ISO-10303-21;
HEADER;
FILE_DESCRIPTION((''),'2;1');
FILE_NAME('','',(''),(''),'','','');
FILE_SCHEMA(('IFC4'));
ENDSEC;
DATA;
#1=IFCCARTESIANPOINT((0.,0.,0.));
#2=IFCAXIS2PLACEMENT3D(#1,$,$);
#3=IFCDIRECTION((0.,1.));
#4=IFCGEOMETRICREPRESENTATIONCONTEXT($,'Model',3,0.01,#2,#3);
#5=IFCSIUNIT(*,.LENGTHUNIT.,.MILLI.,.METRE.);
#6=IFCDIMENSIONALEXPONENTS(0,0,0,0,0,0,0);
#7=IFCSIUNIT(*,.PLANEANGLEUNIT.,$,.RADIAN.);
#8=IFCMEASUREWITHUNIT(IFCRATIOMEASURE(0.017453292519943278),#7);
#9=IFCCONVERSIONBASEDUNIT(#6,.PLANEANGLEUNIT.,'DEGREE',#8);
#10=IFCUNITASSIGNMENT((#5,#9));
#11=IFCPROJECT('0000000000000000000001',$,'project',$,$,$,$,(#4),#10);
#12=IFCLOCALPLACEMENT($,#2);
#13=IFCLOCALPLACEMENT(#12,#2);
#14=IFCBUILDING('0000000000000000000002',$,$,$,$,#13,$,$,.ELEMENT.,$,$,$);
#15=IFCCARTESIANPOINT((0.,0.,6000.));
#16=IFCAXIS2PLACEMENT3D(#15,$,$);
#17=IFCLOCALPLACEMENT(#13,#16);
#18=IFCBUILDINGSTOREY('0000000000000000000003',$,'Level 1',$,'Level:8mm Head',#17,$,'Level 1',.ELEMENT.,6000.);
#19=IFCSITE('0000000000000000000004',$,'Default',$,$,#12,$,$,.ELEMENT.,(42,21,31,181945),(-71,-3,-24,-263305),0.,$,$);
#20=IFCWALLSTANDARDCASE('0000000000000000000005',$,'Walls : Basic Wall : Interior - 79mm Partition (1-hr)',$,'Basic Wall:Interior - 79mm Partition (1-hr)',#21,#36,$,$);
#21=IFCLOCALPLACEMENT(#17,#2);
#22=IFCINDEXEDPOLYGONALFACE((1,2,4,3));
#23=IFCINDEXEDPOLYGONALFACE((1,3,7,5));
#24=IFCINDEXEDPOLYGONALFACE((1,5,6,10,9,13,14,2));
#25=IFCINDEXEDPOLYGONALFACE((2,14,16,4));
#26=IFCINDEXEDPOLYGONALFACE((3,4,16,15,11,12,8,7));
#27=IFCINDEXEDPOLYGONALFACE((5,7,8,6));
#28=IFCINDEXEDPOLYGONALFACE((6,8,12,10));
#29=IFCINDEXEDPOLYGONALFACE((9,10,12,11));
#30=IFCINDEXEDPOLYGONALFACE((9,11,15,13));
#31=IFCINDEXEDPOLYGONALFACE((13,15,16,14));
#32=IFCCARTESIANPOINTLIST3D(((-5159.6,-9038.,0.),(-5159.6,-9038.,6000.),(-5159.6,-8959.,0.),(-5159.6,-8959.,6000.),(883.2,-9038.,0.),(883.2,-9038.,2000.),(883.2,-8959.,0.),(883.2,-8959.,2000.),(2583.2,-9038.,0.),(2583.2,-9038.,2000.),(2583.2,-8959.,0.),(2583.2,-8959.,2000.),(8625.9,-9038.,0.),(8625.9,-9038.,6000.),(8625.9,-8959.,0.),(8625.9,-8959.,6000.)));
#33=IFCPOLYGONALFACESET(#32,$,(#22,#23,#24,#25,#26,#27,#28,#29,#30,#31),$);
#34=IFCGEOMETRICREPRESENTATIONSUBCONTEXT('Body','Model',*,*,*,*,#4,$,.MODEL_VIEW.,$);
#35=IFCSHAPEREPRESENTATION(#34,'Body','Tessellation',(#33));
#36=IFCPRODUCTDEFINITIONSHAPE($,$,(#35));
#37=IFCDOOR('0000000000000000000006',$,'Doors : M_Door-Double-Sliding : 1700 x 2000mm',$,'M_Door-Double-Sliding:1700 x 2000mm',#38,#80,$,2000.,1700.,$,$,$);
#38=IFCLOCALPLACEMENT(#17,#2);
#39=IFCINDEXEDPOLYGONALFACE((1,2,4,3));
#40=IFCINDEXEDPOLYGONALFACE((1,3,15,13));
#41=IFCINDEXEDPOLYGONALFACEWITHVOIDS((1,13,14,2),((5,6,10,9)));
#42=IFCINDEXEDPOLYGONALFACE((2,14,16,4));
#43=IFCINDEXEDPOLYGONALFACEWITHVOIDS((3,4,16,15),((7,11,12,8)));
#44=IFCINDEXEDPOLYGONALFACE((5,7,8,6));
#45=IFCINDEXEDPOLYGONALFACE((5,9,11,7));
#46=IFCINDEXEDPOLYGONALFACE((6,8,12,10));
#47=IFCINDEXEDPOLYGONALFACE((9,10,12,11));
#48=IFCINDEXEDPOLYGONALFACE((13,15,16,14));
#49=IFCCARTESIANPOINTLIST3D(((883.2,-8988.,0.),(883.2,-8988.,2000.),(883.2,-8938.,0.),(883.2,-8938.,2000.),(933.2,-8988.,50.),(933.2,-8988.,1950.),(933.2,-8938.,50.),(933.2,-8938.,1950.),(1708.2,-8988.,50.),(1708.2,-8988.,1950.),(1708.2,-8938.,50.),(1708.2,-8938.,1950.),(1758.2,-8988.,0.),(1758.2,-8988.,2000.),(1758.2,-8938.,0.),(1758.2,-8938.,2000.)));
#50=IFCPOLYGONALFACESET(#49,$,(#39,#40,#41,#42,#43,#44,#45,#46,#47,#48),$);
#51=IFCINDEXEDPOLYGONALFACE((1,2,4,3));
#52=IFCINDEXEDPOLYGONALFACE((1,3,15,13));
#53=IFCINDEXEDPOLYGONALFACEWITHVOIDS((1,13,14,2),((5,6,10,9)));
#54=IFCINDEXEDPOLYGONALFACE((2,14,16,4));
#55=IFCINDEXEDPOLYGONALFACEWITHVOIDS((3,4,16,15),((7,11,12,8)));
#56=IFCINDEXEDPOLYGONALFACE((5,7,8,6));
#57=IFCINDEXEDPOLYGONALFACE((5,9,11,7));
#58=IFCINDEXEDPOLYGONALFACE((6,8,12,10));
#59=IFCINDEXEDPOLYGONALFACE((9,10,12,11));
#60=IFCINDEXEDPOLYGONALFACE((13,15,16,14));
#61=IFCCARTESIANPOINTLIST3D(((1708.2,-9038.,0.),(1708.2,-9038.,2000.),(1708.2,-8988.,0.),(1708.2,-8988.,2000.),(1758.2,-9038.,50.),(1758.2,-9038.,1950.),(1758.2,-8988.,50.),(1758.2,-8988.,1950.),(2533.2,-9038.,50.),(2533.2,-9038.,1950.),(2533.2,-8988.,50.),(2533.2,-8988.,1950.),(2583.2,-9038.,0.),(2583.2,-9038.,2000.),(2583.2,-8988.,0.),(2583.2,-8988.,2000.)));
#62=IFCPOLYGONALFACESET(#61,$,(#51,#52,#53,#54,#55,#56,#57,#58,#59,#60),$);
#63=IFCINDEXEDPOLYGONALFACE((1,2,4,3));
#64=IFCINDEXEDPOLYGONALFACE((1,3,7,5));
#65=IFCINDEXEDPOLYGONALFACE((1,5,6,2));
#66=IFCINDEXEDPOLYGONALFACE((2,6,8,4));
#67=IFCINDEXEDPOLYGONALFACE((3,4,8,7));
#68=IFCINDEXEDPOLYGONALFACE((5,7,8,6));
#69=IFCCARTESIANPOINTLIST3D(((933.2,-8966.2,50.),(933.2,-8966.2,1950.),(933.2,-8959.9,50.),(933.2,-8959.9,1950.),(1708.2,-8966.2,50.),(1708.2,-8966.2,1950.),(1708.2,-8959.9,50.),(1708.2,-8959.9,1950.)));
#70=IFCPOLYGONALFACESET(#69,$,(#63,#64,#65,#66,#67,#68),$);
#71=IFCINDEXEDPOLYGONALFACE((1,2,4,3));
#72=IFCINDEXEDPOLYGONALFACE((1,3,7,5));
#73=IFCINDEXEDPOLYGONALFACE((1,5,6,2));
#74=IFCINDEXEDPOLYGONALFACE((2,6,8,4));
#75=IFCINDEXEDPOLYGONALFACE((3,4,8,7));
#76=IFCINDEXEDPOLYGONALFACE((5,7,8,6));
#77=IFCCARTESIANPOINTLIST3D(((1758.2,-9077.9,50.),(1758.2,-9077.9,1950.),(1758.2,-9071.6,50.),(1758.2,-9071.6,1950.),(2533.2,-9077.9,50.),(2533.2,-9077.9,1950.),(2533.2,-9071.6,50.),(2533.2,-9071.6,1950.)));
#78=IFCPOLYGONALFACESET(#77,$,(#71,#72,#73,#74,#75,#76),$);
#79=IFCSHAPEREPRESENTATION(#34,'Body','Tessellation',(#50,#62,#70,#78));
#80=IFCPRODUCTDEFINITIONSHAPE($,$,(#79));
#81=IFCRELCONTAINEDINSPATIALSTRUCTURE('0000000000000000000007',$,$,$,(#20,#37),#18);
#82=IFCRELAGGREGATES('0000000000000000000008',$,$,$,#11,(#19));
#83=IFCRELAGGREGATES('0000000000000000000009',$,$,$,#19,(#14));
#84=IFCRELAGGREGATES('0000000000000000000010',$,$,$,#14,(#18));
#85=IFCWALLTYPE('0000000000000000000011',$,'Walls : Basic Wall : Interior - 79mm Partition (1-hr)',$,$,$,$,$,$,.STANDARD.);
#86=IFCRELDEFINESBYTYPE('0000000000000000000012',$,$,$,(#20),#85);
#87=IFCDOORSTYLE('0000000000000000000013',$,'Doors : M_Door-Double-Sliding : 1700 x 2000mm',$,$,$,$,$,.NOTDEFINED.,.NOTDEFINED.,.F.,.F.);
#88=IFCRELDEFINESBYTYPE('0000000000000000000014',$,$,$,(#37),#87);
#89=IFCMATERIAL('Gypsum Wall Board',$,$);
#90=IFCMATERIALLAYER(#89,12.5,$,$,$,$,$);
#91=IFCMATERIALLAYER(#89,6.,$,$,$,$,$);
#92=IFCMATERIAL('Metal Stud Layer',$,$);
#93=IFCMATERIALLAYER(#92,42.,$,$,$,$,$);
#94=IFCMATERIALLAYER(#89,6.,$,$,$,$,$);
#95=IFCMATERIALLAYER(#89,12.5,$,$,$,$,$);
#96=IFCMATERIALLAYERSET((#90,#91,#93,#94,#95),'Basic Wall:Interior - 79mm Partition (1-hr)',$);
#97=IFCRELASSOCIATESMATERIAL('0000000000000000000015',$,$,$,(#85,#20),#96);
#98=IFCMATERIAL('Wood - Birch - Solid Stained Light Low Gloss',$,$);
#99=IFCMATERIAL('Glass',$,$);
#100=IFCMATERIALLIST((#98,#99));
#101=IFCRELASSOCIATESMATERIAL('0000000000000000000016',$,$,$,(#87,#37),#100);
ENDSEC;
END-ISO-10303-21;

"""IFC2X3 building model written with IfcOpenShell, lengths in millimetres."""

from ifc_helpers import new_model, entity, si_unit, converted_unit, direction, frame, frame_2d, origin, origin_2d_with_axis, place, context, subcontext, project, spatial, polyline, rectangle, outline, extrude, source, transform, mapped, material, material_list, layer, layer_set, layer_usage, type_object, type_shapes, element, fill, save


model = new_model("IFC2X3")

# Units and contexts
model_context = context("Model", 3, precision=0.01, world=origin(), true_north=direction((0.0, 1.0)))
body_context = subcontext(model_context, "Body", "Model", "MODEL_VIEW")
ifc_project = project(units=[si_unit("LENGTHUNIT", "METRE", prefix="MILLI"), converted_unit("PLANEANGLEUNIT", "DEGREE", entity("IfcRatioMeasure", 0.017453292519943278), si_unit("PLANEANGLEUNIT", "RADIAN"), dimensions=[0, 0, 0, 0, 0, 0, 0])], contexts=[model_context])

# Site, building, storey
site_placement = place(None, origin())
site = spatial("IfcSite", under=ifc_project, at=site_placement, Name="Default", CompositionType="ELEMENT", RefLatitude=(42, 21, 31, 181945), RefLongitude=(-71, -3, -24, -263305), RefElevation=0.0)
building_placement = place(site_placement, origin())
building = spatial("IfcBuilding", under=site, at=building_placement, CompositionType="ELEMENT")
storey_placement = place(building_placement, frame((0.0, 0.0, 6000.0)))
storey = spatial("IfcBuildingStorey", under=building, at=storey_placement, Name="Level 1", ObjectType="Level:8mm Head", LongName="Level 1", CompositionType="ELEMENT", Elevation=6000.0)

# Shared definitions
ifc_material_1 = material(Name="Gypsum Wall Board")
ifc_layer_1 = layer(ifc_material_1, 12.5)
ifc_layer_2 = layer(ifc_material_1, 6.0)
ifc_material_2 = material(Name="Metal Stud Layer")
ifc_layer_3 = layer(ifc_material_2, 42.0)
ifc_layer_4 = layer(ifc_material_1, 6.0)
ifc_layer_5 = layer(ifc_material_1, 12.5)
ifc_layer_set_1 = layer_set([ifc_layer_1, ifc_layer_2, ifc_layer_3, ifc_layer_4, ifc_layer_5], Name="Basic Wall:Interior - 79mm Partition (1-hr)")
ifc_layer_usage_1 = layer_usage(ifc_layer_set_1, "AXIS2", "NEGATIVE", 39.5)
wall_type = type_object("IfcWallType", Name="Walls : Basic Wall : Interior - 79mm Partition (1-hr)", PredefinedType="STANDARD", material=ifc_layer_set_1)

# Wall, opening, door
ifc_material_3 = material(Name="Wood - Birch - Solid Stained Light Low Gloss")
ifc_material_4 = material(Name="Glass")
ifc_material_list = material_list([ifc_material_3, ifc_material_4])
door_style = type_object("IfcDoorStyle", Name="Doors : M_Door-Double-Sliding : 1700 x 2000mm", ConstructionType="NOTDEFINED", OperationType="NOTDEFINED", ParameterTakesPrecedence=False, Sizeable=False, material=ifc_material_list)
shared_shape = source(origin(), body_context, "Body", "SweptSolid", [
    extrude(outline(polyline([(-437.5, -1000.0), (437.5, -1000.0), (437.5, 1000.0), (-437.5, 1000.0), (-437.5, -1000.0)]), holes=[polyline([(-387.5, -950.0), (-387.5, 950.0), (387.5, 950.0), (387.5, -950.0), (-387.5, -950.0)])]), frame((1262.5, -21.0, 1000.0), z_axis=(0.0, 1.0, 0.0), x_axis=(1.0, 0.0, 0.0)), (0.0, 0.0, 1.0), 50.0),
    extrude(outline(polyline([(-1000.0, -437.5), (1000.0, -437.5), (1000.0, 437.5), (-1000.0, 437.5), (-1000.0, -437.5)]), holes=[polyline([(-950.0, -387.5), (-950.0, 387.5), (950.0, 387.5), (950.0, -387.5), (-950.0, -387.5)])]), frame((437.5, 29.0, 1000.0), z_axis=(0.0, 1.0, 0.0), x_axis=(0.0, 0.0, -1.0)), (0.0, 0.0, 1.0), 50.0),
    extrude(rectangle(XDim=6.3, YDim=775.0, at=frame_2d((0.0, 0.0), x_axis=(1.0, 0.0))), frame((1262.5, 4.0, 50.0), z_axis=(0.0, 0.0, 1.0), x_axis=(0.0, -1.0, 0.0)), (0.0, 0.0, 1.0), 1900.0),
    extrude(rectangle(XDim=6.4, YDim=775.0, at=origin_2d_with_axis()), frame((437.5, 115.7, 50.0), z_axis=(0.0, 0.0, 1.0), x_axis=(0.0, 1.0, 0.0)), (0.0, 0.0, 1.0), 1900.0),
])
type_shapes(door_style, [shared_shape])
wall_1_placement = place(storey_placement, frame((-5159.6, -8998.5, 0.0)))
wall_1 = element("IfcWallStandardCase", 1, at=wall_1_placement, inside=storey, type_object=wall_type, material=ifc_layer_usage_1, Name="Walls : Basic Wall : Interior - 79mm Partition (1-hr)", ObjectType="Basic Wall:Interior - 79mm Partition (1-hr)", context=body_context, shape_type="SweptSolid", body=[
    extrude(rectangle(XDim=13785.5, YDim=79.0, at=frame_2d((6892.8, 0.0), x_axis=(1.0, 0.0))), origin(), (0.0, 0.0, 1.0), 6000.0),
])
opening_1_placement = place(wall_1_placement, frame((7742.8, 39.5, 0.0)))
opening_1 = element("IfcOpeningElement", 2, at=opening_1_placement, cuts=wall_1, ObjectType="Opening", context=body_context, shape_type="SweptSolid", body=[
    extrude(rectangle(XDim=2000.0, YDim=1700.0, at=frame_2d((1000.0, 850.0), x_axis=(-1.0, 0.0))), frame((0.0, 0.0, 0.0), z_axis=(0.0, -1.0, 0.0), x_axis=(0.0, 0.0, 1.0)), (0.0, 0.0, 1.0), 79.0),
])
door_1_placement = place(opening_1_placement, frame((0.0, 0.0, 0.0), z_axis=(0.0, 0.0, 1.0), x_axis=(-1.0, 0.0, 0.0)))
door_1 = element("IfcDoor", 3, at=door_1_placement, inside=storey, type_object=door_style, material=ifc_material_list, Name="Doors : M_Door-Double-Sliding : 1700 x 2000mm", ObjectType="M_Door-Double-Sliding:1700 x 2000mm", OverallHeight=2000.0, OverallWidth=1700.0, context=body_context, shape_type="MappedRepresentation", body=[
    mapped(shared_shape, transform((0.0, 0.0, 0.0), scale=1.0)),
])
fill(opening_1, door_1)

save(model, "model.ifc")
